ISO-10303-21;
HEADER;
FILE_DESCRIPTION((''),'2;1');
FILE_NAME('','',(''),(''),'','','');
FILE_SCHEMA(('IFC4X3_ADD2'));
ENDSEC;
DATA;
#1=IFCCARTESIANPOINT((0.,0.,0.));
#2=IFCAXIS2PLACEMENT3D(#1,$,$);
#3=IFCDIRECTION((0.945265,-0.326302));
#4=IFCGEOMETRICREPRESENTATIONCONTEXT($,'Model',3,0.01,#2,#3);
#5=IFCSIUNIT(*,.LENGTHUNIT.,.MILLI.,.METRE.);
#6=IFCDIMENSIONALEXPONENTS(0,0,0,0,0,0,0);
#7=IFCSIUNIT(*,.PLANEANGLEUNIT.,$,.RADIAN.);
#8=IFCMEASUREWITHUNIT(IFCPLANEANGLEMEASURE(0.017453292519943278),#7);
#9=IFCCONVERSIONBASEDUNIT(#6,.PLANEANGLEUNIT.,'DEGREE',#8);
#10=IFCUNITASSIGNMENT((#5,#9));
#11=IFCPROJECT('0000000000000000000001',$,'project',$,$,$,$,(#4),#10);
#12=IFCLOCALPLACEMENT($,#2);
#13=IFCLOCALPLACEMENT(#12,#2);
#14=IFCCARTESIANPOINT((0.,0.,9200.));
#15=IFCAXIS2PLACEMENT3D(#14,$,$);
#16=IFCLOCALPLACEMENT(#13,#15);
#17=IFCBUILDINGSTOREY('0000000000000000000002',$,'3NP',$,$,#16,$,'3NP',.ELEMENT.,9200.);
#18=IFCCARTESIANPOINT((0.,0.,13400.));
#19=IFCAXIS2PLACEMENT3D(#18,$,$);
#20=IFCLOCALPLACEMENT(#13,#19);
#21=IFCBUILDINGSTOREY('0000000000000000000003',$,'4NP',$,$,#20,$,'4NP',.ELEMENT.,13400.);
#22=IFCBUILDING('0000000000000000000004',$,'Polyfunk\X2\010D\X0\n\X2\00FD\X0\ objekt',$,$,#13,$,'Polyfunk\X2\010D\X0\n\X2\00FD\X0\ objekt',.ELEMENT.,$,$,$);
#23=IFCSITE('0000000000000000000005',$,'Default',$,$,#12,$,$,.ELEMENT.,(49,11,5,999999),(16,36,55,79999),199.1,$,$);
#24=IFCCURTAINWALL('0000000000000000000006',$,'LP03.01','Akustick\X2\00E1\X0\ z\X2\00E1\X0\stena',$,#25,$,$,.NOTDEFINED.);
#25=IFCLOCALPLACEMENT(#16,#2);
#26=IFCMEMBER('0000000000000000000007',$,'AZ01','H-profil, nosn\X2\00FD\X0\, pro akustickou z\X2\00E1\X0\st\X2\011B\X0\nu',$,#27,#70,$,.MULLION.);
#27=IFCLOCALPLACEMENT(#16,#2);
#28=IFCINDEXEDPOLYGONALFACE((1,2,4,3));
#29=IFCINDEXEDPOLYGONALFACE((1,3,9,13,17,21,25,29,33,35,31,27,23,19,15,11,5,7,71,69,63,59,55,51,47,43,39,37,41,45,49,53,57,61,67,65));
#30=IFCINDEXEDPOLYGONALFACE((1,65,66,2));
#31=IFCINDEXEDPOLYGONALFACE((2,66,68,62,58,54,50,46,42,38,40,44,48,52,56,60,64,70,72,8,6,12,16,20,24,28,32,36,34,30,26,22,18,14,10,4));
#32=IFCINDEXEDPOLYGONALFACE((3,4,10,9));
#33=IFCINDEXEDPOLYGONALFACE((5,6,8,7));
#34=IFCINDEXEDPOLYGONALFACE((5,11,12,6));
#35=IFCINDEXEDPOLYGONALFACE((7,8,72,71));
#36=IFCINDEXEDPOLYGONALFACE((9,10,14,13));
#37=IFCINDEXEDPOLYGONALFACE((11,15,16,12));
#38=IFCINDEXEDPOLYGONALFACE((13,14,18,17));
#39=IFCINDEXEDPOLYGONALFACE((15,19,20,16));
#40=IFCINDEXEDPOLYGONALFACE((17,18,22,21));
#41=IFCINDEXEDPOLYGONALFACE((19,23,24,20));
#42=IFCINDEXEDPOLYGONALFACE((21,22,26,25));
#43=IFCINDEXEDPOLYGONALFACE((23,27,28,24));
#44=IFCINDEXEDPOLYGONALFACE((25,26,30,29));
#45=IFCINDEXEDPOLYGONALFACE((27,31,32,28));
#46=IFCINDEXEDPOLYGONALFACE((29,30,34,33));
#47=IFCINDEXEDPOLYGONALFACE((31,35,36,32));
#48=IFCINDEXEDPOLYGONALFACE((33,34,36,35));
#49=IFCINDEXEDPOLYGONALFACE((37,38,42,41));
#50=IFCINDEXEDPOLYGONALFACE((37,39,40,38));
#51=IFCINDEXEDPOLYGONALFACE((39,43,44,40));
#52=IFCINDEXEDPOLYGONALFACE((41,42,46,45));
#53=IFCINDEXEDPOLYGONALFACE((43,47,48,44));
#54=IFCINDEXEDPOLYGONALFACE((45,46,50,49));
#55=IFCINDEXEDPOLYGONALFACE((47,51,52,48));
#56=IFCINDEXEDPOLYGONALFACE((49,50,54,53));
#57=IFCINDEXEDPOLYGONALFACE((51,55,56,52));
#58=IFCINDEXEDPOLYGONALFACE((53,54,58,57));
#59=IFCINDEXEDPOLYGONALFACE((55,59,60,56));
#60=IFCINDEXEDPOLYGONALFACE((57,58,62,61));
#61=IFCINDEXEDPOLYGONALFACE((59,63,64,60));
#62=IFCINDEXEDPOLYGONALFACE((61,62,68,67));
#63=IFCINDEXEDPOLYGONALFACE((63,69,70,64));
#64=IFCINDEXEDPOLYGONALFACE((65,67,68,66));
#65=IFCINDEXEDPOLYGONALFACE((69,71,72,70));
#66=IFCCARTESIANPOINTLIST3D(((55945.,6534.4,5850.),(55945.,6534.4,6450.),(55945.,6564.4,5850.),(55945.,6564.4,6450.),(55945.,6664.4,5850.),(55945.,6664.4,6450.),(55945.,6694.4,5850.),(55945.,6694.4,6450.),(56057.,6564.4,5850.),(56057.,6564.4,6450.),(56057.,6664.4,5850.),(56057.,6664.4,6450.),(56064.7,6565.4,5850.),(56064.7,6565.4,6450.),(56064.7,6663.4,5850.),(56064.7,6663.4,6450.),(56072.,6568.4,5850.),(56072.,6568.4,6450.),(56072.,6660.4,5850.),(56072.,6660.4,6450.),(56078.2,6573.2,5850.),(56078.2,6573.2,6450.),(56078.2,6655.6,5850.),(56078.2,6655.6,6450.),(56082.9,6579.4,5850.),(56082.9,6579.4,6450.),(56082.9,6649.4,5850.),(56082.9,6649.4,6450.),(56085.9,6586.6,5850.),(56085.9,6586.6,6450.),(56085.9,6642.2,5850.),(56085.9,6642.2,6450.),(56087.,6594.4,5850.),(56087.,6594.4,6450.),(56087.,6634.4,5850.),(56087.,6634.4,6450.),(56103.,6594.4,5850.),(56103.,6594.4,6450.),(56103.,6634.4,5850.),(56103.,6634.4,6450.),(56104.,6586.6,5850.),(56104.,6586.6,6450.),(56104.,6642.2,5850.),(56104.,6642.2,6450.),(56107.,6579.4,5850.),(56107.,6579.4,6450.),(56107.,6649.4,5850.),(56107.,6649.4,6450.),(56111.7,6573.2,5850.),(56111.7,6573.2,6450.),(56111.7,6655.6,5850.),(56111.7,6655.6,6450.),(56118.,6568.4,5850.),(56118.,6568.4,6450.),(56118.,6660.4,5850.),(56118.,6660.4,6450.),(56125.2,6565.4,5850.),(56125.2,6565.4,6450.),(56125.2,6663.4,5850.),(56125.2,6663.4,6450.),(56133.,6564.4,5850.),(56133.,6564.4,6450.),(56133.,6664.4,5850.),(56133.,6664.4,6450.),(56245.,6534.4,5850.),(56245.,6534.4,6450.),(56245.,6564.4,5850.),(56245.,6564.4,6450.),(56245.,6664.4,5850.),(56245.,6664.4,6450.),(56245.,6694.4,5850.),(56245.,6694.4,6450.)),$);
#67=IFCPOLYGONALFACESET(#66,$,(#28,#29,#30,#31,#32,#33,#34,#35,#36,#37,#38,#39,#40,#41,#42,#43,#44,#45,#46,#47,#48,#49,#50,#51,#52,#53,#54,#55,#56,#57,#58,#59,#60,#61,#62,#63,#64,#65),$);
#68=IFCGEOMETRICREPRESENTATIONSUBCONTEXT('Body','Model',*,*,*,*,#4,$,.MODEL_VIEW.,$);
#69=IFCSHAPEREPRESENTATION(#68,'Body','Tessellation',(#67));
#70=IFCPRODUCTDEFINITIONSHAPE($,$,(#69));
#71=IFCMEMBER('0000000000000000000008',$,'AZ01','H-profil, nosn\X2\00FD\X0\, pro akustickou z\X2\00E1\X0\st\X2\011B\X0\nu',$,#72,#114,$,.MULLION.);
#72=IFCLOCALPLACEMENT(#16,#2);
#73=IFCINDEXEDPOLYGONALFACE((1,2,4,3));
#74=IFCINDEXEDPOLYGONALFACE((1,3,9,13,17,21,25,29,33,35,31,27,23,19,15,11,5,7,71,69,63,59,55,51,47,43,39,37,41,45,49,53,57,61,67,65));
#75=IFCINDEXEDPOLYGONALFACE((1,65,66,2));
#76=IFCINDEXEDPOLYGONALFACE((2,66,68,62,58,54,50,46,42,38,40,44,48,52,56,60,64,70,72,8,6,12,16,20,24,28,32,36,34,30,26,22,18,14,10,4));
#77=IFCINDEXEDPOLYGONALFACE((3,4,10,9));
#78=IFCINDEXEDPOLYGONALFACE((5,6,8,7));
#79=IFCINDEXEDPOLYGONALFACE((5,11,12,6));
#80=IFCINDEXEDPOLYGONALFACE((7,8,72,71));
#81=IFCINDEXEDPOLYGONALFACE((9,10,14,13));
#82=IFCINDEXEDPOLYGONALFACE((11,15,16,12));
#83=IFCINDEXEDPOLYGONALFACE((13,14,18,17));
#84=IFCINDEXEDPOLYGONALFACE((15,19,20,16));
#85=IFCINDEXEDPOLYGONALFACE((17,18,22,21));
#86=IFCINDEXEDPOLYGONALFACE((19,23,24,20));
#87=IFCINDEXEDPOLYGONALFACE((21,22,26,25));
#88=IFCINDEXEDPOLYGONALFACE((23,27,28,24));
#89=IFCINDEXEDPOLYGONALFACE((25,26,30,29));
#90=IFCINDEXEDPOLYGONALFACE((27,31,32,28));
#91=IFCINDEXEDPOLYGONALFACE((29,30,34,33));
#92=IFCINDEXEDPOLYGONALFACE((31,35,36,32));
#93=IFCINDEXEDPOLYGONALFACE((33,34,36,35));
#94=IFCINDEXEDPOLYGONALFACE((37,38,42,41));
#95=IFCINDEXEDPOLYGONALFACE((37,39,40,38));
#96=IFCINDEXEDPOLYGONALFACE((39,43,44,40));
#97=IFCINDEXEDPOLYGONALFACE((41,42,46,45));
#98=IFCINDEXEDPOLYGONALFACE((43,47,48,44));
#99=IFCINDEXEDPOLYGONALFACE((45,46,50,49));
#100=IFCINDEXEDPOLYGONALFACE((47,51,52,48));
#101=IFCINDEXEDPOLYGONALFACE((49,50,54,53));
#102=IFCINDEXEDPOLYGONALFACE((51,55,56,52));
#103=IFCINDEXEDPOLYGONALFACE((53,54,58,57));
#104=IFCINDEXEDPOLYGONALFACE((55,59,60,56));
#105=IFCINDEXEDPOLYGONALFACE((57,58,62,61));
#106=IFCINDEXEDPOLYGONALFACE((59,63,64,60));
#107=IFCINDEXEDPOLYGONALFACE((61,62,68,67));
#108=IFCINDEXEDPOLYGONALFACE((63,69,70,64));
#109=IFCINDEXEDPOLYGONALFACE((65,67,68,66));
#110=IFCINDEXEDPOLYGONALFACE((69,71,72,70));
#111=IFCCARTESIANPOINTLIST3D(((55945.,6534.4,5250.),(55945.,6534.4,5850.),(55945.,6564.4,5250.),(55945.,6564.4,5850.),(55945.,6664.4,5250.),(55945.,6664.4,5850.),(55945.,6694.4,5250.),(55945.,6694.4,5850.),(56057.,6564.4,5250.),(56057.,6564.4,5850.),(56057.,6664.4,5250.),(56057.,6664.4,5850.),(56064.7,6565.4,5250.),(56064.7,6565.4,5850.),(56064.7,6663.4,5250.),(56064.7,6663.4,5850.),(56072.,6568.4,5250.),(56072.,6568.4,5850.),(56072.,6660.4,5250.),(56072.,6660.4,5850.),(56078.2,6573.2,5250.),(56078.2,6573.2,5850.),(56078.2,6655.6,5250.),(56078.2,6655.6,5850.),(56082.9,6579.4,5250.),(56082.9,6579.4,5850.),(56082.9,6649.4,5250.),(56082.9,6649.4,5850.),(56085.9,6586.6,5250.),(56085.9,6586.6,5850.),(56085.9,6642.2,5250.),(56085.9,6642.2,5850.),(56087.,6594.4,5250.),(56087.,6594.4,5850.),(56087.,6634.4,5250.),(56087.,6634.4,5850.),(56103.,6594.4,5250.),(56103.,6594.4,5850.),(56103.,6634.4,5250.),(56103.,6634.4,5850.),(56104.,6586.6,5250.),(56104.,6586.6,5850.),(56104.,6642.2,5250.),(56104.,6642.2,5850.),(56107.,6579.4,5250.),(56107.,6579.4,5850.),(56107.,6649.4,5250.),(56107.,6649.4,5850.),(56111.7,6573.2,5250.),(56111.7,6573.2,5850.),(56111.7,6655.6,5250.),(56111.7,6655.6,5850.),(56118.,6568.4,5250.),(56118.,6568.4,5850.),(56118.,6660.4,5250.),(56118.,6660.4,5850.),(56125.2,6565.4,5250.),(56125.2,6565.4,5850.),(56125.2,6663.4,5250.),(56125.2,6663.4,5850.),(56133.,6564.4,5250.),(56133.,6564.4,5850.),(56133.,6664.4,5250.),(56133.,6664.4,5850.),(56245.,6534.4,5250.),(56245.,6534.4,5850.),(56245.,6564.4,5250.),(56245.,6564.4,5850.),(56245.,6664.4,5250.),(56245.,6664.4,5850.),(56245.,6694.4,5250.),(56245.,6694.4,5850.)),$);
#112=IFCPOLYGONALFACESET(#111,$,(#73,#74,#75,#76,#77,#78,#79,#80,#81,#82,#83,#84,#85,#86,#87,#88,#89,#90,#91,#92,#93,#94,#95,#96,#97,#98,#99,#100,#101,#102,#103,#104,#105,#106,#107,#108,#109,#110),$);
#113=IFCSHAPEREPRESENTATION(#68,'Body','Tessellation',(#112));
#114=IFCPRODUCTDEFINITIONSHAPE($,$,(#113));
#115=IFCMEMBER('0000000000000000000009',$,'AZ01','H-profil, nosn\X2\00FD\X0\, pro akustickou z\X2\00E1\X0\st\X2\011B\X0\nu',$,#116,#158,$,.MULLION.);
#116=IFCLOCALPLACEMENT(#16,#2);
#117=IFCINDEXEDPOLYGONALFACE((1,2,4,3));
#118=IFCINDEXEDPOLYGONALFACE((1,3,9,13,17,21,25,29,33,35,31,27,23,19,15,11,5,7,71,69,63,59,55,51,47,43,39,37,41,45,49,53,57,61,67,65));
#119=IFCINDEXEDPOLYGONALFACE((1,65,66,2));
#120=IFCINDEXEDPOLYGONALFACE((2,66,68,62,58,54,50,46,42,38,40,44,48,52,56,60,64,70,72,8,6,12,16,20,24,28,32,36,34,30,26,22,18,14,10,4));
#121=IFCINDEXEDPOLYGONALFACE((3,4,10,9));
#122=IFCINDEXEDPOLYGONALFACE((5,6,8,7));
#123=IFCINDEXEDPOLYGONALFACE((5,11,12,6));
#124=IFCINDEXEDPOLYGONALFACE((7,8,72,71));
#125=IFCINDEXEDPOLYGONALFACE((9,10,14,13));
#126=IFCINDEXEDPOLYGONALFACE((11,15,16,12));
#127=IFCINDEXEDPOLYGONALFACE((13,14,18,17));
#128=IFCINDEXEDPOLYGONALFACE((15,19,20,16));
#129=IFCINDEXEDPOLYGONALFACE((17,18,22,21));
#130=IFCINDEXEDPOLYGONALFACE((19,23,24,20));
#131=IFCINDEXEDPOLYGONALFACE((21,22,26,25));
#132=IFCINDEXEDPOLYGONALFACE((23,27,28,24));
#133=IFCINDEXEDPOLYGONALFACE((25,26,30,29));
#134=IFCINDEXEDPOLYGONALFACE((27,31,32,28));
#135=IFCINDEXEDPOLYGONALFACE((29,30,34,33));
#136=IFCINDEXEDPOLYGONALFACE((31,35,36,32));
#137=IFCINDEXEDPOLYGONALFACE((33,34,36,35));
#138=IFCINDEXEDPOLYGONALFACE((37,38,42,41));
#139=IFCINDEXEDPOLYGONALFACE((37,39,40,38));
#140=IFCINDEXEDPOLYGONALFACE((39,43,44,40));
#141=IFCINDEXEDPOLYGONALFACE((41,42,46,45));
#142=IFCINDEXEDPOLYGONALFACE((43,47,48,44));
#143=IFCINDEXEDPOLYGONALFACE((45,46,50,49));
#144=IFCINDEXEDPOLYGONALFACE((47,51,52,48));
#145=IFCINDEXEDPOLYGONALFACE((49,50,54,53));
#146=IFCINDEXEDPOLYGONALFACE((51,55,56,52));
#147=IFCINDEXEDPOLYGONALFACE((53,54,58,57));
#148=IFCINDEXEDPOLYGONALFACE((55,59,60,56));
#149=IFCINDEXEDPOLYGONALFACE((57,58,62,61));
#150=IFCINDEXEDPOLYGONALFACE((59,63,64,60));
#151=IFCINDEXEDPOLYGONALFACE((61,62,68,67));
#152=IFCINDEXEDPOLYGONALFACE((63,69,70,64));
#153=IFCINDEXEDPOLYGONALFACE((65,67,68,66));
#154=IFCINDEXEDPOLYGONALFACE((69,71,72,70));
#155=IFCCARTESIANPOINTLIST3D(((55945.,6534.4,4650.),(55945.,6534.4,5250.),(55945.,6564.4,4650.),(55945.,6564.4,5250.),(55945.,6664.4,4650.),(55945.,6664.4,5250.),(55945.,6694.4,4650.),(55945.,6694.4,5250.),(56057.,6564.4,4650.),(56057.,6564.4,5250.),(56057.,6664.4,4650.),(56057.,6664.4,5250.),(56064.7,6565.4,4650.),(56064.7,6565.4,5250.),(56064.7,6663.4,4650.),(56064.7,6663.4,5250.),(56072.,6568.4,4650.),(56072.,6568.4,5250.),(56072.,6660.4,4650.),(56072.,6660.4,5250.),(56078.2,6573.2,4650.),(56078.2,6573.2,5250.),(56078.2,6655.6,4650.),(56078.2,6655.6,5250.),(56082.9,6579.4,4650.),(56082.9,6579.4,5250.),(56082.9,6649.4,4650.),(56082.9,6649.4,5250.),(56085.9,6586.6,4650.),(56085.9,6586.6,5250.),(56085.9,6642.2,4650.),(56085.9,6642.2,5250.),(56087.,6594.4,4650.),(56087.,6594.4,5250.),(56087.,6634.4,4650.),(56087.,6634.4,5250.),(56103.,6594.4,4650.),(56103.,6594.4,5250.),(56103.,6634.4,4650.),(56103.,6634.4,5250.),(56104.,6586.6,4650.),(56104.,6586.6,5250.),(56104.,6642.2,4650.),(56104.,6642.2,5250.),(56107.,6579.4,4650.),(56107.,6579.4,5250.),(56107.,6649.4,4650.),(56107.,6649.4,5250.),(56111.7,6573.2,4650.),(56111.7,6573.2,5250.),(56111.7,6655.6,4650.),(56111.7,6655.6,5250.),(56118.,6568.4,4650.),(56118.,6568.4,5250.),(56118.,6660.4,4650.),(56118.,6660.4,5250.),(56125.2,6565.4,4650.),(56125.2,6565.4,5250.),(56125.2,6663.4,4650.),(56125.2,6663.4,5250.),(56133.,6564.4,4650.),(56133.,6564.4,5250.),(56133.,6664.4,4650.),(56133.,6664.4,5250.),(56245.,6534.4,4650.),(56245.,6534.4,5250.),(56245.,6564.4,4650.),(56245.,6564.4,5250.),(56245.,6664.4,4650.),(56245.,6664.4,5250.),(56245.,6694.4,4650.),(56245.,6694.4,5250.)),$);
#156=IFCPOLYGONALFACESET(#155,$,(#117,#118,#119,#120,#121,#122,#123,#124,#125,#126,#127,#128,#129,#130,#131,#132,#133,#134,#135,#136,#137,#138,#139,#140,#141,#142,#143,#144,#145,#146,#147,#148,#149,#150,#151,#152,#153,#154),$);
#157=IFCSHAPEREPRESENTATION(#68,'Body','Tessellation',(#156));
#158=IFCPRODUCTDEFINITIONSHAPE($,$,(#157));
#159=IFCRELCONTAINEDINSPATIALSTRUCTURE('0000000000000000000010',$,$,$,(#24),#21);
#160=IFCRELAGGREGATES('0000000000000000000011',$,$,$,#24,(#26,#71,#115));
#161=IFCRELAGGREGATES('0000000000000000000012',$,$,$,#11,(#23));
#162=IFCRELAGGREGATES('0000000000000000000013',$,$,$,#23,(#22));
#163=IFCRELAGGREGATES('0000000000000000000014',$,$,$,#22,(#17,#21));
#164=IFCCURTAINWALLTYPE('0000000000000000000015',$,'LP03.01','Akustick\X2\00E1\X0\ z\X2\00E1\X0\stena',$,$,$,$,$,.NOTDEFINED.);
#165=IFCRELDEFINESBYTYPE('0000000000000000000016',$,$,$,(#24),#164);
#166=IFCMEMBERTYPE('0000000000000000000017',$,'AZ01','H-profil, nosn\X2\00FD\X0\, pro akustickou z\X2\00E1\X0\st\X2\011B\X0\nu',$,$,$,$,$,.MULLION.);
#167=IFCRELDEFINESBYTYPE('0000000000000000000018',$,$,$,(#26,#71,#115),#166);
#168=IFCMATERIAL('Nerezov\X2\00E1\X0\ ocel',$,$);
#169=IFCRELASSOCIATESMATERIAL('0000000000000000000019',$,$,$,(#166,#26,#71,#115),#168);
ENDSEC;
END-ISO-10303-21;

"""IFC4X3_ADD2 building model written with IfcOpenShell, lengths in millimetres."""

from ifc_helpers import new_model, entity, si_unit, converted_unit, direction, frame, frame_2d, origin, place, context, subcontext, project, spatial, polyline, circle_curve, parameter, trimmed, segment, composite_curve, outline, extrude, source, transform, mapped, material, material_profile, profile_set, profile_usage, type_object, element, aggregate, save


model = new_model("IFC4X3_ADD2")

# Units and contexts
model_context = context("Model", 3, precision=0.01, world=origin(), true_north=direction((0.945265, -0.326302)))
body_context = subcontext(model_context, "Body", "Model", "MODEL_VIEW")
ifc_project = project(units=[si_unit("LENGTHUNIT", "METRE", prefix="MILLI"), converted_unit("PLANEANGLEUNIT", "DEGREE", entity("IfcPlaneAngleMeasure", 0.017453292519943278), si_unit("PLANEANGLEUNIT", "RADIAN"), dimensions=[0, 0, 0, 0, 0, 0, 0])], contexts=[model_context])

# Site, building, storey
site_placement = place(None, origin())
site = spatial("IfcSite", under=ifc_project, at=site_placement, Name="Default", CompositionType="ELEMENT", RefLatitude=(49, 11, 5, 999999), RefLongitude=(16, 36, 55, 79999), RefElevation=199.1)
building_placement = place(site_placement, origin())
building = spatial("IfcBuilding", under=site, at=building_placement, Name="Polyfunkčný objekt", LongName="Polyfunkčný objekt", CompositionType="ELEMENT")
storey_1_placement = place(building_placement, frame((0.0, 0.0, 9200.0)))
storey_1 = spatial("IfcBuildingStorey", under=building, at=storey_1_placement, Name="3NP", LongName="3NP", CompositionType="ELEMENT", Elevation=9200.0)

# Shared definitions
storey_2_placement = place(building_placement, frame((0.0, 0.0, 13400.0)))
storey_2 = spatial("IfcBuildingStorey", under=building, at=storey_2_placement, Name="4NP", LongName="4NP", CompositionType="ELEMENT", Elevation=13400.0)

# Curtain wall, members
curtain_wall_type_1 = type_object("IfcCurtainWallType", Name="LP03.01", Description="Akustická zástena", PredefinedType="NOTDEFINED")
curtain_wall_1_placement = place(storey_2_placement, frame((0.0, 0.0, -13400.0)))
curtain_wall_1 = element("IfcCurtainWall", 1, at=curtain_wall_1_placement, inside=storey_2, type_object=curtain_wall_type_1, Name="LP03.01", Description="Akustická zástena", PredefinedType="NOTDEFINED")
ifc_material_1 = material(Name="Nerezová ocel")
ifc_material_profile_1 = material_profile(ifc_material_1, outline(composite_curve([segment(polyline([(50.0, -150.0), (80.0, -150.0)]), True, "CONTINUOUS"), segment(polyline([(80.0, -150.0), (80.0, 150.0)]), True, "CONTINUOUS"), segment(polyline([(80.0, 150.0), (50.0, 150.0)]), True, "CONTINUOUS"), segment(polyline([(50.0, 150.0), (50.0, 38.0)]), True, "CONTINUOUS"), segment(trimmed(circle_curve(frame_2d((20.0, 38.0), x_axis=(0.0, 1.0)), 30.0), [parameter(180.0)], [parameter(270.0)], True, "PARAMETER"), False, "CONTINUOUS"), segment(polyline([(20.0, 8.0), (-20.0, 8.0)]), True, "CONTINUOUS"), segment(trimmed(circle_curve(frame_2d((-20.0, 38.0), x_axis=(0.0, 1.0)), 30.0), [parameter(90.0)], [parameter(180.0)], True, "PARAMETER"), False, "CONTINUOUS"), segment(polyline([(-50.0, 38.0), (-50.0, 150.0)]), True, "CONTINUOUS"), segment(polyline([(-50.0, 150.0), (-80.0, 150.0)]), True, "CONTINUOUS"), segment(polyline([(-80.0, 150.0), (-80.0, -150.0)]), True, "CONTINUOUS"), segment(polyline([(-80.0, -150.0), (-50.0, -150.0)]), True, "CONTINUOUS"), segment(polyline([(-50.0, -150.0), (-50.0, -38.0)]), True, "CONTINUOUS"), segment(trimmed(circle_curve(frame_2d((-20.0, -38.0), x_axis=(0.0, 1.0)), 30.0), [parameter(0.0)], [parameter(90.0)], True, "PARAMETER"), False, "CONTINUOUS"), segment(polyline([(-20.0, -8.0), (20.0, -8.0)]), True, "CONTINUOUS"), segment(trimmed(circle_curve(frame_2d((20.0, -38.0), x_axis=(0.0, 1.0)), 30.0), [parameter(270.0)], [parameter(0.0)], True, "PARAMETER"), False, "CONTINUOUS"), segment(polyline([(50.0, -38.0), (50.0, -150.0)]), True, "CONTINUOUS")], self_intersect=False)), Name="Profil zástena")
ifc_profile_set_1 = profile_set([ifc_material_profile_1], Name="Profil zástena")
ifc_profile_usage_1 = profile_usage(ifc_profile_set_1)
member_type_1 = type_object("IfcMemberType", Name="AZ01", Description="H-profil, nosný, pro akustickou zástěnu", PredefinedType="MULLION", material=ifc_profile_set_1)
shared_shape_1 = source(origin(), body_context, "Body", "SweptSolid", [
    extrude(outline(composite_curve([segment(polyline([(50.0, -150.0), (80.0, -150.0)]), True, "CONTINUOUS"), segment(polyline([(80.0, -150.0), (80.0, 150.0)]), True, "CONTINUOUS"), segment(polyline([(80.0, 150.0), (50.0, 150.0)]), True, "CONTINUOUS"), segment(polyline([(50.0, 150.0), (50.0, 38.0)]), True, "CONTINUOUS"), segment(trimmed(circle_curve(frame_2d((20.0, 38.0), x_axis=(0.0, 1.0)), 30.0), [parameter(180.0)], [parameter(270.0)], True, "PARAMETER"), False, "CONTINUOUS"), segment(polyline([(20.0, 8.0), (-20.0, 8.0)]), True, "CONTINUOUS"), segment(trimmed(circle_curve(frame_2d((-20.0, 38.0), x_axis=(0.0, 1.0)), 30.0), [parameter(90.0)], [parameter(180.0)], True, "PARAMETER"), False, "CONTINUOUS"), segment(polyline([(-50.0, 38.0), (-50.0, 150.0)]), True, "CONTINUOUS"), segment(polyline([(-50.0, 150.0), (-80.0, 150.0)]), True, "CONTINUOUS"), segment(polyline([(-80.0, 150.0), (-80.0, -150.0)]), True, "CONTINUOUS"), segment(polyline([(-80.0, -150.0), (-50.0, -150.0)]), True, "CONTINUOUS"), segment(polyline([(-50.0, -150.0), (-50.0, -38.0)]), True, "CONTINUOUS"), segment(trimmed(circle_curve(frame_2d((-20.0, -38.0), x_axis=(0.0, 1.0)), 30.0), [parameter(0.0)], [parameter(90.0)], True, "PARAMETER"), False, "CONTINUOUS"), segment(polyline([(-20.0, -8.0), (20.0, -8.0)]), True, "CONTINUOUS"), segment(trimmed(circle_curve(frame_2d((20.0, -38.0), x_axis=(0.0, 1.0)), 30.0), [parameter(270.0)], [parameter(0.0)], True, "PARAMETER"), False, "CONTINUOUS"), segment(polyline([(50.0, -38.0), (50.0, -150.0)]), True, "CONTINUOUS")], self_intersect=False)), frame((-150.0, 0.0, -600.0), z_axis=(0.0, 0.0, 1.0), x_axis=(0.0, -1.0, 0.0)), (0.0, 0.0, 1.0), 600.0),
])
member_1_placement = place(curtain_wall_1_placement, frame((56245.0, 6614.4, 15050.0), z_axis=(0.0, 0.0, -1.0), x_axis=(1.0, 0.0, 0.0)))
member_1 = element("IfcMember", 2, at=member_1_placement, type_object=member_type_1, material=ifc_profile_usage_1, Name="AZ01", Description="H-profil, nosný, pro akustickou zástěnu", PredefinedType="MULLION", context=body_context, shape_type="MappedRepresentation", body=[
    mapped(shared_shape_1, transform((0.0, 0.0, 0.0), scale=1.0)),
])
member_2_placement = place(curtain_wall_1_placement, frame((56245.0, 6614.4, 14450.0), z_axis=(0.0, 0.0, -1.0), x_axis=(1.0, 0.0, 0.0)))
member_2 = element("IfcMember", 3, at=member_2_placement, type_object=member_type_1, material=ifc_profile_usage_1, Name="AZ01", Description="H-profil, nosný, pro akustickou zástěnu", PredefinedType="MULLION", context=body_context, shape_type="MappedRepresentation", body=[
    mapped(shared_shape_1, transform((0.0, 0.0, 0.0), scale=1.0)),
])
member_3_placement = place(curtain_wall_1_placement, frame((56245.0, 6614.4, 13850.0), z_axis=(0.0, 0.0, -1.0), x_axis=(1.0, 0.0, 0.0)))
member_3 = element("IfcMember", 4, at=member_3_placement, type_object=member_type_1, material=ifc_profile_usage_1, Name="AZ01", Description="H-profil, nosný, pro akustickou zástěnu", PredefinedType="MULLION", context=body_context, shape_type="MappedRepresentation", body=[
    mapped(shared_shape_1, transform((0.0, 0.0, 0.0), scale=1.0)),
])
aggregate(curtain_wall_1, [member_1, member_2, member_3])

save(model, "model.ifc")
